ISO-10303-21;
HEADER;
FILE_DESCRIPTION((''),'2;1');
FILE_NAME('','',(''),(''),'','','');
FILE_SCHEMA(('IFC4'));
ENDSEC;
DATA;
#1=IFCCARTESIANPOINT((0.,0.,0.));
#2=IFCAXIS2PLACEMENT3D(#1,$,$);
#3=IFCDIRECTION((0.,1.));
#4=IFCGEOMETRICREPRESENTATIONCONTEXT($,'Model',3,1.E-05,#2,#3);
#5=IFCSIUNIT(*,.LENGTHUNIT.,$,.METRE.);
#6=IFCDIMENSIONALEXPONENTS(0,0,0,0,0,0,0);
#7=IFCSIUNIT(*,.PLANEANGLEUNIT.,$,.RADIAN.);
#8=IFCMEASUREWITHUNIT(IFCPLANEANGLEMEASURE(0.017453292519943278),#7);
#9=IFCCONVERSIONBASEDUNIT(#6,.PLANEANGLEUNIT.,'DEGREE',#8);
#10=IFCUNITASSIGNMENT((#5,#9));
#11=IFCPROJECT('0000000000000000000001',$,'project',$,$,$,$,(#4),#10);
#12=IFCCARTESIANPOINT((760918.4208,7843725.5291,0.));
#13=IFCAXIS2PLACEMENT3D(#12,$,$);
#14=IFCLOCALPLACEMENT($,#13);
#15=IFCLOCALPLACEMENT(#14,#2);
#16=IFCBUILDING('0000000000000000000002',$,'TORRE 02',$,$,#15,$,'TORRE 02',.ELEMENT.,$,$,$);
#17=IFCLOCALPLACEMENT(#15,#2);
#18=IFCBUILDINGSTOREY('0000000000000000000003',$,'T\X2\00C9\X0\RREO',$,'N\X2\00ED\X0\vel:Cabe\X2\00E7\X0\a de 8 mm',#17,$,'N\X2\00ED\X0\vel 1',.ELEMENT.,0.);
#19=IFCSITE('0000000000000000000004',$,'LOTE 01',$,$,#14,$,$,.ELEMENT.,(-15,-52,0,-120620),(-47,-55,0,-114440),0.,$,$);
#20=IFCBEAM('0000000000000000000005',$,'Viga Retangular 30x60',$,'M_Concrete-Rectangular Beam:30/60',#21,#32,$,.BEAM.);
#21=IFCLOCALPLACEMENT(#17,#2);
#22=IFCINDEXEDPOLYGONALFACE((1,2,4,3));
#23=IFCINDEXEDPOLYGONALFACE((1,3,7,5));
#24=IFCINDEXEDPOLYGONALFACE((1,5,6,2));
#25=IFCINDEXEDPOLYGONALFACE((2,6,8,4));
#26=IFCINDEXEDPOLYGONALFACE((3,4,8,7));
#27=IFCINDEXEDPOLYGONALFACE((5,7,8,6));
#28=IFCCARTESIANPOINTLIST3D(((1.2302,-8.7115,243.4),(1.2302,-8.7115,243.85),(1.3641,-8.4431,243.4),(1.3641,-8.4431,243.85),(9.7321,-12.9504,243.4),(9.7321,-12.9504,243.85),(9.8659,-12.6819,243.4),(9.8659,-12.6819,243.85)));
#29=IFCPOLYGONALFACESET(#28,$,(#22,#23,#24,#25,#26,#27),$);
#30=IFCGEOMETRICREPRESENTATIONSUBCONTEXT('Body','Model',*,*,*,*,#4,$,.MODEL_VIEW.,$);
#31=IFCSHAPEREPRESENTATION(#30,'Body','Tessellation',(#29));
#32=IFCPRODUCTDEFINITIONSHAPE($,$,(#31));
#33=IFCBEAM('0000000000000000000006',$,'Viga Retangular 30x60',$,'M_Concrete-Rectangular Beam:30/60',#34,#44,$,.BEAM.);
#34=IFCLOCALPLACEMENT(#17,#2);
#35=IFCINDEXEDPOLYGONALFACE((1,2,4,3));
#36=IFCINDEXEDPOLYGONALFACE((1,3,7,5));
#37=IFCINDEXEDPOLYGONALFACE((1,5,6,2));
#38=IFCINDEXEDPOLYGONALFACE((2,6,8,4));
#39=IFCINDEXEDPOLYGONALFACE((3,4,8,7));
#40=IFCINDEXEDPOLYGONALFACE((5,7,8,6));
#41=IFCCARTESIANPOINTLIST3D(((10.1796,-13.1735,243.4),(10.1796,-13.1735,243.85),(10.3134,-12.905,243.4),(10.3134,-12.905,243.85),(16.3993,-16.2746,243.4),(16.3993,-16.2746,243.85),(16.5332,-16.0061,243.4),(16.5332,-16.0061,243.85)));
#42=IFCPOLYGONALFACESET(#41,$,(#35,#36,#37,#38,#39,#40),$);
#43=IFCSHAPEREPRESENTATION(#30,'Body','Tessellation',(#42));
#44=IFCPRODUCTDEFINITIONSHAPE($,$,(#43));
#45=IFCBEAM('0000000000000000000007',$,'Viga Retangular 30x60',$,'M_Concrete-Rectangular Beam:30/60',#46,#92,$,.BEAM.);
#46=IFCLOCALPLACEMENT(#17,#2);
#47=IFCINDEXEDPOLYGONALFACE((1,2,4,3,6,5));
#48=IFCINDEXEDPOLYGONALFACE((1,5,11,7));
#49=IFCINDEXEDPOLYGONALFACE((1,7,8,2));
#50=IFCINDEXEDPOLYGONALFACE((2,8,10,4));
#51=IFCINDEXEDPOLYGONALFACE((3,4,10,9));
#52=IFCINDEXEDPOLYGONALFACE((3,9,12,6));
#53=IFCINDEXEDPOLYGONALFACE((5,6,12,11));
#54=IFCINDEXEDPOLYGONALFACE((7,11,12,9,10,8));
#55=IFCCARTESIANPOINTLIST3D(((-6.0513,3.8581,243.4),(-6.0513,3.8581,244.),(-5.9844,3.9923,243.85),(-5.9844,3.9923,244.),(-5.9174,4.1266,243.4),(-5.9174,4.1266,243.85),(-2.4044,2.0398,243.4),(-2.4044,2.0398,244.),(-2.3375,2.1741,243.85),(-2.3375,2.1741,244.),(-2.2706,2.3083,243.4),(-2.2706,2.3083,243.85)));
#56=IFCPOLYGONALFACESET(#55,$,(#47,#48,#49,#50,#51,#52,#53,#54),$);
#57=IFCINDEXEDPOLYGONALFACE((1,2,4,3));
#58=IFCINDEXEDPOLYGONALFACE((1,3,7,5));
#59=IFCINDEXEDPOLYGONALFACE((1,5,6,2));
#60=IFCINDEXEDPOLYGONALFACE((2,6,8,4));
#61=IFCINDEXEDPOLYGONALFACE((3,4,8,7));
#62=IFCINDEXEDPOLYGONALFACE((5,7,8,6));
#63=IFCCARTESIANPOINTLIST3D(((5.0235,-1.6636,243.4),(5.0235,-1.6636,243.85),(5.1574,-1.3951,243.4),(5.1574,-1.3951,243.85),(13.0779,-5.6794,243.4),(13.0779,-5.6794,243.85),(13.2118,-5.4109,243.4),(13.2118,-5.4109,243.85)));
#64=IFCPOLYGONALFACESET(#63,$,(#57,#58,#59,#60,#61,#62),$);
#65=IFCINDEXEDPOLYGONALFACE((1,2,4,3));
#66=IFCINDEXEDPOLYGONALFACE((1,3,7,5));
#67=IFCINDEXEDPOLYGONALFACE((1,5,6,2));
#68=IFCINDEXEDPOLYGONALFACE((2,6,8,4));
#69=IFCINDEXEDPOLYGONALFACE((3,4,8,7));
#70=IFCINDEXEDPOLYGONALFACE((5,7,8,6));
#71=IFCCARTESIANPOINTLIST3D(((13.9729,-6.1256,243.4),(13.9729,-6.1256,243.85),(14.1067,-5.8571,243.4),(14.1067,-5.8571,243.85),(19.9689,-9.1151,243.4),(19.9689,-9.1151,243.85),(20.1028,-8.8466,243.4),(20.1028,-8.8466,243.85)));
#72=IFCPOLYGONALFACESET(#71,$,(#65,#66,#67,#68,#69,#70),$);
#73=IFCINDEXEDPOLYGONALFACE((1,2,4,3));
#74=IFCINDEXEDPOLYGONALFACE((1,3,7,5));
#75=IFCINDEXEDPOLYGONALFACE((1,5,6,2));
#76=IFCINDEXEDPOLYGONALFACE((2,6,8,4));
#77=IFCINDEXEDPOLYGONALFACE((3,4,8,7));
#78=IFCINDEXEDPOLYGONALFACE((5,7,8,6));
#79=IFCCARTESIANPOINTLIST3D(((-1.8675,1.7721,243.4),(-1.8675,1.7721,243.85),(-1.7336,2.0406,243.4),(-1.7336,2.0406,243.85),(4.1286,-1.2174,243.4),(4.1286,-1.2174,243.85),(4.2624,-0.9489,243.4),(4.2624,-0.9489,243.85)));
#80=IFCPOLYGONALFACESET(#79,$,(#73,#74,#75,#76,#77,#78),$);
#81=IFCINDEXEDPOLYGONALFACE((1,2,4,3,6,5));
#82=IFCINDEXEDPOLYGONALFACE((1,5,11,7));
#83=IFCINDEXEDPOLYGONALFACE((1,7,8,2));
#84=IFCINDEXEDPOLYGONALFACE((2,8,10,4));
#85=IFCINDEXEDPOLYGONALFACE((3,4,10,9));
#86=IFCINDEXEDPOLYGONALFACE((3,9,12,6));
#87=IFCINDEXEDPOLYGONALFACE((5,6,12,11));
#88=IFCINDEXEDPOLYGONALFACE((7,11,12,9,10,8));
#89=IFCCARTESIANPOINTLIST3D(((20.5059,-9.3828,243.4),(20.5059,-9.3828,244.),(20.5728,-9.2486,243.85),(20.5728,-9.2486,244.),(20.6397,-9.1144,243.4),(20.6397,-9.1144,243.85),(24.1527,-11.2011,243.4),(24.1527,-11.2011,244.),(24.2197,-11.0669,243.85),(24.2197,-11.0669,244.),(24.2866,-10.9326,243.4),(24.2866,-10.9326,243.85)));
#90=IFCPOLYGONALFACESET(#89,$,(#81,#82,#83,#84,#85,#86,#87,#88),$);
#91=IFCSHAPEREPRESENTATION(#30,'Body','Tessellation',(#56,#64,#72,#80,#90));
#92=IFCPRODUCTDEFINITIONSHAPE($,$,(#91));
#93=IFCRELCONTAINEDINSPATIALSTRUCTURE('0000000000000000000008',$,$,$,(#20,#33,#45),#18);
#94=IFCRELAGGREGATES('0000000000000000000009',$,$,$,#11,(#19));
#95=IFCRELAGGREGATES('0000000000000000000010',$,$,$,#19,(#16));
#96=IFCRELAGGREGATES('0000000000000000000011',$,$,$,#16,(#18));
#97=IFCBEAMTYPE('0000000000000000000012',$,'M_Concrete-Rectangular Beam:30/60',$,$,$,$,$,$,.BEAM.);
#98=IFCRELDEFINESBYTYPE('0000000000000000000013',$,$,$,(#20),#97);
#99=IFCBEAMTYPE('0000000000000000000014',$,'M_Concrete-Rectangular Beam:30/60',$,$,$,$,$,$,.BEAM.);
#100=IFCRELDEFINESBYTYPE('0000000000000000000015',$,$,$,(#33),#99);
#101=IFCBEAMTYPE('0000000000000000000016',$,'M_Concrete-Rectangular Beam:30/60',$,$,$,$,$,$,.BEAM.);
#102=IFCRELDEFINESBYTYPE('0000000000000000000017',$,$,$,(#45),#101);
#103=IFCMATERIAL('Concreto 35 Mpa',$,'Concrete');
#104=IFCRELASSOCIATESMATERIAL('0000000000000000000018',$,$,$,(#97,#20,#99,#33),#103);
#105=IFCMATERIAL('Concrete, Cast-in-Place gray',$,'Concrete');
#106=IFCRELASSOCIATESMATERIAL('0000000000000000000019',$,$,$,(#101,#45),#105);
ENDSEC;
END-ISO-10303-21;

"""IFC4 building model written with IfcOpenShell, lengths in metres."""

from ifc_helpers import new_model, entity, si_unit, converted_unit, direction, frame, origin, place, context, subcontext, project, spatial, indexed_curve, outline, extrude, source, transform, mapped, material, type_object, type_shapes, element, save


model = new_model("IFC4")

# Units and contexts
model_context = context("Model", 3, precision=1e-05, world=origin(), true_north=direction((0.0, 1.0)))
body_context = subcontext(model_context, "Body", "Model", "MODEL_VIEW")
ifc_project = project(units=[si_unit("LENGTHUNIT", "METRE"), converted_unit("PLANEANGLEUNIT", "DEGREE", entity("IfcPlaneAngleMeasure", 0.017453292519943278), si_unit("PLANEANGLEUNIT", "RADIAN"), dimensions=[0, 0, 0, 0, 0, 0, 0])], contexts=[model_context])

# Site, building, storey
site_placement = place(None, frame((760918.4208, 7843725.5291, 0.0)))
site = spatial("IfcSite", under=ifc_project, at=site_placement, Name="LOTE 01", CompositionType="ELEMENT", RefLatitude=(-15, -52, 0, -120620), RefLongitude=(-47, -55, 0, -114440), RefElevation=0.0)
building_placement = place(site_placement, origin())
building = spatial("IfcBuilding", under=site, at=building_placement, Name="TORRE 02", LongName="TORRE 02", CompositionType="ELEMENT")
storey_placement = place(building_placement, origin())
storey = spatial("IfcBuildingStorey", under=building, at=storey_placement, Name="TÉRREO", ObjectType="Nível:Cabeça de 8 mm", LongName="Nível 1", CompositionType="ELEMENT", Elevation=0.0)

# Shared definitions
ifc_material_1 = material(Name="Concrete, Cast-in-Place gray", Category="Concrete")
placement = place(building_placement, frame((0.0, 0.0, 244.0)))

# Beams
ifc_material_2 = material(Name="Concreto 35 Mpa", Category="Concrete")
beam_type_1 = type_object("IfcBeamType", Name="M_Concrete-Rectangular Beam:30/60", PredefinedType="BEAM", material=ifc_material_2)
shared_shape_1 = source(origin(), body_context, "Body", "SweptSolid", [
    extrude(outline(indexed_curve([(-0.225, -0.15), (0.225, -0.15), (0.225, 0.15), (-0.225, 0.15), (-0.225, -0.15)], self_intersect=False)), frame((1.2971, -8.5773, 243.625), z_axis=(0.894934, -0.446198, 0.0), x_axis=(0.0, 0.0, -1.0)), (0.0, 0.0, 1.0), 9.5),
])
type_shapes(beam_type_1, [shared_shape_1])
beam_1_placement = place(placement, frame((0.0, 0.0, -244.0)))
element("IfcBeam", 1, at=beam_1_placement, inside=storey, type_object=beam_type_1, material=ifc_material_2, Name="Viga Retangular 30x60", ObjectType="M_Concrete-Rectangular Beam:30/60", PredefinedType="BEAM", context=body_context, shape_type="MappedRepresentation", body=[
    mapped(shared_shape_1, transform((0.0, 0.0, 0.0), scale=1.0)),
])
beam_type_2 = type_object("IfcBeamType", Name="M_Concrete-Rectangular Beam:30/60", PredefinedType="BEAM", material=ifc_material_2)
shared_shape_2 = source(origin(), body_context, "Body", "SweptSolid", [
    extrude(outline(indexed_curve([(-0.225, -0.15), (0.225, -0.15), (0.225, 0.15), (-0.225, 0.15), (-0.225, -0.15)], self_intersect=False)), frame((10.2465, -13.0393, 243.625), z_axis=(0.894934, -0.446198, 0.0), x_axis=(0.0, 0.0, -1.0)), (0.0, 0.0, 1.0), 6.95),
])
type_shapes(beam_type_2, [shared_shape_2])
beam_2_placement = place(placement, frame((0.0, 0.0, -244.0)))
element("IfcBeam", 2, at=beam_2_placement, inside=storey, type_object=beam_type_2, material=ifc_material_2, Name="Viga Retangular 30x60", ObjectType="M_Concrete-Rectangular Beam:30/60", PredefinedType="BEAM", context=body_context, shape_type="MappedRepresentation", body=[
    mapped(shared_shape_2, transform((0.0, 0.0, 0.0), scale=1.0)),
])
beam_type_3 = type_object("IfcBeamType", Name="M_Concrete-Rectangular Beam:30/60", PredefinedType="BEAM", material=ifc_material_1)
shared_shape_3 = source(origin(), body_context, "Body", "SweptSolid", [
    extrude(outline(indexed_curve([(-0.35, -0.15), (0.25, -0.15), (0.25, 0.0), (0.1, 0.0), (0.1, 0.15), (-0.35, 0.15), (-0.35, -0.15)], self_intersect=False)), frame((-2.3375, 2.1741, 243.75), z_axis=(-0.894934, 0.446198, 0.0), x_axis=(0.0, 0.0, 1.0)), (0.0, 0.0, 1.0), 4.075),
    extrude(outline(indexed_curve([(-0.225, -0.15), (0.225, -0.15), (0.225, 0.15), (-0.225, 0.15), (-0.225, -0.15)], self_intersect=False)), frame((13.1449, -5.5452, 243.625), z_axis=(-0.894934, 0.446198, 0.0), x_axis=(0.0, 0.0, 1.0)), (0.0, 0.0, 1.0), 9.0),
    extrude(outline(indexed_curve([(-0.225, -0.15), (0.225, -0.15), (0.225, 0.15), (-0.225, 0.15), (-0.225, -0.15)], self_intersect=False)), frame((20.0359, -8.9809, 243.625), z_axis=(-0.894934, 0.446198, 0.0), x_axis=(0.0, 0.0, 1.0)), (0.0, 0.0, 1.0), 6.7),
    extrude(outline(indexed_curve([(-0.225, -0.15), (0.225, -0.15), (0.225, 0.15), (-0.225, 0.15), (-0.225, -0.15)], self_intersect=False)), frame((4.1955, -1.0832, 243.625), z_axis=(-0.894934, 0.446198, 0.0), x_axis=(0.0, 0.0, 1.0)), (0.0, 0.0, 1.0), 6.7),
    extrude(outline(indexed_curve([(-0.35, -0.15), (0.25, -0.15), (0.25, 0.0), (0.1, 0.0), (0.1, 0.15), (-0.35, 0.15), (-0.35, -0.15)], self_intersect=False)), frame((24.2197, -11.0669, 243.75), z_axis=(-0.894934, 0.446198, 0.0), x_axis=(0.0, 0.0, 1.0)), (0.0, 0.0, 1.0), 4.075),
])
type_shapes(beam_type_3, [shared_shape_3])
beam_3_placement = place(placement, frame((0.0, 0.0, -244.0)))
element("IfcBeam", 3, at=beam_3_placement, inside=storey, type_object=beam_type_3, material=ifc_material_1, Name="Viga Retangular 30x60", ObjectType="M_Concrete-Rectangular Beam:30/60", PredefinedType="BEAM", context=body_context, shape_type="MappedRepresentation", body=[
    mapped(shared_shape_3, transform((0.0, 0.0, 0.0), scale=1.0)),
])

save(model, "model.ifc")
